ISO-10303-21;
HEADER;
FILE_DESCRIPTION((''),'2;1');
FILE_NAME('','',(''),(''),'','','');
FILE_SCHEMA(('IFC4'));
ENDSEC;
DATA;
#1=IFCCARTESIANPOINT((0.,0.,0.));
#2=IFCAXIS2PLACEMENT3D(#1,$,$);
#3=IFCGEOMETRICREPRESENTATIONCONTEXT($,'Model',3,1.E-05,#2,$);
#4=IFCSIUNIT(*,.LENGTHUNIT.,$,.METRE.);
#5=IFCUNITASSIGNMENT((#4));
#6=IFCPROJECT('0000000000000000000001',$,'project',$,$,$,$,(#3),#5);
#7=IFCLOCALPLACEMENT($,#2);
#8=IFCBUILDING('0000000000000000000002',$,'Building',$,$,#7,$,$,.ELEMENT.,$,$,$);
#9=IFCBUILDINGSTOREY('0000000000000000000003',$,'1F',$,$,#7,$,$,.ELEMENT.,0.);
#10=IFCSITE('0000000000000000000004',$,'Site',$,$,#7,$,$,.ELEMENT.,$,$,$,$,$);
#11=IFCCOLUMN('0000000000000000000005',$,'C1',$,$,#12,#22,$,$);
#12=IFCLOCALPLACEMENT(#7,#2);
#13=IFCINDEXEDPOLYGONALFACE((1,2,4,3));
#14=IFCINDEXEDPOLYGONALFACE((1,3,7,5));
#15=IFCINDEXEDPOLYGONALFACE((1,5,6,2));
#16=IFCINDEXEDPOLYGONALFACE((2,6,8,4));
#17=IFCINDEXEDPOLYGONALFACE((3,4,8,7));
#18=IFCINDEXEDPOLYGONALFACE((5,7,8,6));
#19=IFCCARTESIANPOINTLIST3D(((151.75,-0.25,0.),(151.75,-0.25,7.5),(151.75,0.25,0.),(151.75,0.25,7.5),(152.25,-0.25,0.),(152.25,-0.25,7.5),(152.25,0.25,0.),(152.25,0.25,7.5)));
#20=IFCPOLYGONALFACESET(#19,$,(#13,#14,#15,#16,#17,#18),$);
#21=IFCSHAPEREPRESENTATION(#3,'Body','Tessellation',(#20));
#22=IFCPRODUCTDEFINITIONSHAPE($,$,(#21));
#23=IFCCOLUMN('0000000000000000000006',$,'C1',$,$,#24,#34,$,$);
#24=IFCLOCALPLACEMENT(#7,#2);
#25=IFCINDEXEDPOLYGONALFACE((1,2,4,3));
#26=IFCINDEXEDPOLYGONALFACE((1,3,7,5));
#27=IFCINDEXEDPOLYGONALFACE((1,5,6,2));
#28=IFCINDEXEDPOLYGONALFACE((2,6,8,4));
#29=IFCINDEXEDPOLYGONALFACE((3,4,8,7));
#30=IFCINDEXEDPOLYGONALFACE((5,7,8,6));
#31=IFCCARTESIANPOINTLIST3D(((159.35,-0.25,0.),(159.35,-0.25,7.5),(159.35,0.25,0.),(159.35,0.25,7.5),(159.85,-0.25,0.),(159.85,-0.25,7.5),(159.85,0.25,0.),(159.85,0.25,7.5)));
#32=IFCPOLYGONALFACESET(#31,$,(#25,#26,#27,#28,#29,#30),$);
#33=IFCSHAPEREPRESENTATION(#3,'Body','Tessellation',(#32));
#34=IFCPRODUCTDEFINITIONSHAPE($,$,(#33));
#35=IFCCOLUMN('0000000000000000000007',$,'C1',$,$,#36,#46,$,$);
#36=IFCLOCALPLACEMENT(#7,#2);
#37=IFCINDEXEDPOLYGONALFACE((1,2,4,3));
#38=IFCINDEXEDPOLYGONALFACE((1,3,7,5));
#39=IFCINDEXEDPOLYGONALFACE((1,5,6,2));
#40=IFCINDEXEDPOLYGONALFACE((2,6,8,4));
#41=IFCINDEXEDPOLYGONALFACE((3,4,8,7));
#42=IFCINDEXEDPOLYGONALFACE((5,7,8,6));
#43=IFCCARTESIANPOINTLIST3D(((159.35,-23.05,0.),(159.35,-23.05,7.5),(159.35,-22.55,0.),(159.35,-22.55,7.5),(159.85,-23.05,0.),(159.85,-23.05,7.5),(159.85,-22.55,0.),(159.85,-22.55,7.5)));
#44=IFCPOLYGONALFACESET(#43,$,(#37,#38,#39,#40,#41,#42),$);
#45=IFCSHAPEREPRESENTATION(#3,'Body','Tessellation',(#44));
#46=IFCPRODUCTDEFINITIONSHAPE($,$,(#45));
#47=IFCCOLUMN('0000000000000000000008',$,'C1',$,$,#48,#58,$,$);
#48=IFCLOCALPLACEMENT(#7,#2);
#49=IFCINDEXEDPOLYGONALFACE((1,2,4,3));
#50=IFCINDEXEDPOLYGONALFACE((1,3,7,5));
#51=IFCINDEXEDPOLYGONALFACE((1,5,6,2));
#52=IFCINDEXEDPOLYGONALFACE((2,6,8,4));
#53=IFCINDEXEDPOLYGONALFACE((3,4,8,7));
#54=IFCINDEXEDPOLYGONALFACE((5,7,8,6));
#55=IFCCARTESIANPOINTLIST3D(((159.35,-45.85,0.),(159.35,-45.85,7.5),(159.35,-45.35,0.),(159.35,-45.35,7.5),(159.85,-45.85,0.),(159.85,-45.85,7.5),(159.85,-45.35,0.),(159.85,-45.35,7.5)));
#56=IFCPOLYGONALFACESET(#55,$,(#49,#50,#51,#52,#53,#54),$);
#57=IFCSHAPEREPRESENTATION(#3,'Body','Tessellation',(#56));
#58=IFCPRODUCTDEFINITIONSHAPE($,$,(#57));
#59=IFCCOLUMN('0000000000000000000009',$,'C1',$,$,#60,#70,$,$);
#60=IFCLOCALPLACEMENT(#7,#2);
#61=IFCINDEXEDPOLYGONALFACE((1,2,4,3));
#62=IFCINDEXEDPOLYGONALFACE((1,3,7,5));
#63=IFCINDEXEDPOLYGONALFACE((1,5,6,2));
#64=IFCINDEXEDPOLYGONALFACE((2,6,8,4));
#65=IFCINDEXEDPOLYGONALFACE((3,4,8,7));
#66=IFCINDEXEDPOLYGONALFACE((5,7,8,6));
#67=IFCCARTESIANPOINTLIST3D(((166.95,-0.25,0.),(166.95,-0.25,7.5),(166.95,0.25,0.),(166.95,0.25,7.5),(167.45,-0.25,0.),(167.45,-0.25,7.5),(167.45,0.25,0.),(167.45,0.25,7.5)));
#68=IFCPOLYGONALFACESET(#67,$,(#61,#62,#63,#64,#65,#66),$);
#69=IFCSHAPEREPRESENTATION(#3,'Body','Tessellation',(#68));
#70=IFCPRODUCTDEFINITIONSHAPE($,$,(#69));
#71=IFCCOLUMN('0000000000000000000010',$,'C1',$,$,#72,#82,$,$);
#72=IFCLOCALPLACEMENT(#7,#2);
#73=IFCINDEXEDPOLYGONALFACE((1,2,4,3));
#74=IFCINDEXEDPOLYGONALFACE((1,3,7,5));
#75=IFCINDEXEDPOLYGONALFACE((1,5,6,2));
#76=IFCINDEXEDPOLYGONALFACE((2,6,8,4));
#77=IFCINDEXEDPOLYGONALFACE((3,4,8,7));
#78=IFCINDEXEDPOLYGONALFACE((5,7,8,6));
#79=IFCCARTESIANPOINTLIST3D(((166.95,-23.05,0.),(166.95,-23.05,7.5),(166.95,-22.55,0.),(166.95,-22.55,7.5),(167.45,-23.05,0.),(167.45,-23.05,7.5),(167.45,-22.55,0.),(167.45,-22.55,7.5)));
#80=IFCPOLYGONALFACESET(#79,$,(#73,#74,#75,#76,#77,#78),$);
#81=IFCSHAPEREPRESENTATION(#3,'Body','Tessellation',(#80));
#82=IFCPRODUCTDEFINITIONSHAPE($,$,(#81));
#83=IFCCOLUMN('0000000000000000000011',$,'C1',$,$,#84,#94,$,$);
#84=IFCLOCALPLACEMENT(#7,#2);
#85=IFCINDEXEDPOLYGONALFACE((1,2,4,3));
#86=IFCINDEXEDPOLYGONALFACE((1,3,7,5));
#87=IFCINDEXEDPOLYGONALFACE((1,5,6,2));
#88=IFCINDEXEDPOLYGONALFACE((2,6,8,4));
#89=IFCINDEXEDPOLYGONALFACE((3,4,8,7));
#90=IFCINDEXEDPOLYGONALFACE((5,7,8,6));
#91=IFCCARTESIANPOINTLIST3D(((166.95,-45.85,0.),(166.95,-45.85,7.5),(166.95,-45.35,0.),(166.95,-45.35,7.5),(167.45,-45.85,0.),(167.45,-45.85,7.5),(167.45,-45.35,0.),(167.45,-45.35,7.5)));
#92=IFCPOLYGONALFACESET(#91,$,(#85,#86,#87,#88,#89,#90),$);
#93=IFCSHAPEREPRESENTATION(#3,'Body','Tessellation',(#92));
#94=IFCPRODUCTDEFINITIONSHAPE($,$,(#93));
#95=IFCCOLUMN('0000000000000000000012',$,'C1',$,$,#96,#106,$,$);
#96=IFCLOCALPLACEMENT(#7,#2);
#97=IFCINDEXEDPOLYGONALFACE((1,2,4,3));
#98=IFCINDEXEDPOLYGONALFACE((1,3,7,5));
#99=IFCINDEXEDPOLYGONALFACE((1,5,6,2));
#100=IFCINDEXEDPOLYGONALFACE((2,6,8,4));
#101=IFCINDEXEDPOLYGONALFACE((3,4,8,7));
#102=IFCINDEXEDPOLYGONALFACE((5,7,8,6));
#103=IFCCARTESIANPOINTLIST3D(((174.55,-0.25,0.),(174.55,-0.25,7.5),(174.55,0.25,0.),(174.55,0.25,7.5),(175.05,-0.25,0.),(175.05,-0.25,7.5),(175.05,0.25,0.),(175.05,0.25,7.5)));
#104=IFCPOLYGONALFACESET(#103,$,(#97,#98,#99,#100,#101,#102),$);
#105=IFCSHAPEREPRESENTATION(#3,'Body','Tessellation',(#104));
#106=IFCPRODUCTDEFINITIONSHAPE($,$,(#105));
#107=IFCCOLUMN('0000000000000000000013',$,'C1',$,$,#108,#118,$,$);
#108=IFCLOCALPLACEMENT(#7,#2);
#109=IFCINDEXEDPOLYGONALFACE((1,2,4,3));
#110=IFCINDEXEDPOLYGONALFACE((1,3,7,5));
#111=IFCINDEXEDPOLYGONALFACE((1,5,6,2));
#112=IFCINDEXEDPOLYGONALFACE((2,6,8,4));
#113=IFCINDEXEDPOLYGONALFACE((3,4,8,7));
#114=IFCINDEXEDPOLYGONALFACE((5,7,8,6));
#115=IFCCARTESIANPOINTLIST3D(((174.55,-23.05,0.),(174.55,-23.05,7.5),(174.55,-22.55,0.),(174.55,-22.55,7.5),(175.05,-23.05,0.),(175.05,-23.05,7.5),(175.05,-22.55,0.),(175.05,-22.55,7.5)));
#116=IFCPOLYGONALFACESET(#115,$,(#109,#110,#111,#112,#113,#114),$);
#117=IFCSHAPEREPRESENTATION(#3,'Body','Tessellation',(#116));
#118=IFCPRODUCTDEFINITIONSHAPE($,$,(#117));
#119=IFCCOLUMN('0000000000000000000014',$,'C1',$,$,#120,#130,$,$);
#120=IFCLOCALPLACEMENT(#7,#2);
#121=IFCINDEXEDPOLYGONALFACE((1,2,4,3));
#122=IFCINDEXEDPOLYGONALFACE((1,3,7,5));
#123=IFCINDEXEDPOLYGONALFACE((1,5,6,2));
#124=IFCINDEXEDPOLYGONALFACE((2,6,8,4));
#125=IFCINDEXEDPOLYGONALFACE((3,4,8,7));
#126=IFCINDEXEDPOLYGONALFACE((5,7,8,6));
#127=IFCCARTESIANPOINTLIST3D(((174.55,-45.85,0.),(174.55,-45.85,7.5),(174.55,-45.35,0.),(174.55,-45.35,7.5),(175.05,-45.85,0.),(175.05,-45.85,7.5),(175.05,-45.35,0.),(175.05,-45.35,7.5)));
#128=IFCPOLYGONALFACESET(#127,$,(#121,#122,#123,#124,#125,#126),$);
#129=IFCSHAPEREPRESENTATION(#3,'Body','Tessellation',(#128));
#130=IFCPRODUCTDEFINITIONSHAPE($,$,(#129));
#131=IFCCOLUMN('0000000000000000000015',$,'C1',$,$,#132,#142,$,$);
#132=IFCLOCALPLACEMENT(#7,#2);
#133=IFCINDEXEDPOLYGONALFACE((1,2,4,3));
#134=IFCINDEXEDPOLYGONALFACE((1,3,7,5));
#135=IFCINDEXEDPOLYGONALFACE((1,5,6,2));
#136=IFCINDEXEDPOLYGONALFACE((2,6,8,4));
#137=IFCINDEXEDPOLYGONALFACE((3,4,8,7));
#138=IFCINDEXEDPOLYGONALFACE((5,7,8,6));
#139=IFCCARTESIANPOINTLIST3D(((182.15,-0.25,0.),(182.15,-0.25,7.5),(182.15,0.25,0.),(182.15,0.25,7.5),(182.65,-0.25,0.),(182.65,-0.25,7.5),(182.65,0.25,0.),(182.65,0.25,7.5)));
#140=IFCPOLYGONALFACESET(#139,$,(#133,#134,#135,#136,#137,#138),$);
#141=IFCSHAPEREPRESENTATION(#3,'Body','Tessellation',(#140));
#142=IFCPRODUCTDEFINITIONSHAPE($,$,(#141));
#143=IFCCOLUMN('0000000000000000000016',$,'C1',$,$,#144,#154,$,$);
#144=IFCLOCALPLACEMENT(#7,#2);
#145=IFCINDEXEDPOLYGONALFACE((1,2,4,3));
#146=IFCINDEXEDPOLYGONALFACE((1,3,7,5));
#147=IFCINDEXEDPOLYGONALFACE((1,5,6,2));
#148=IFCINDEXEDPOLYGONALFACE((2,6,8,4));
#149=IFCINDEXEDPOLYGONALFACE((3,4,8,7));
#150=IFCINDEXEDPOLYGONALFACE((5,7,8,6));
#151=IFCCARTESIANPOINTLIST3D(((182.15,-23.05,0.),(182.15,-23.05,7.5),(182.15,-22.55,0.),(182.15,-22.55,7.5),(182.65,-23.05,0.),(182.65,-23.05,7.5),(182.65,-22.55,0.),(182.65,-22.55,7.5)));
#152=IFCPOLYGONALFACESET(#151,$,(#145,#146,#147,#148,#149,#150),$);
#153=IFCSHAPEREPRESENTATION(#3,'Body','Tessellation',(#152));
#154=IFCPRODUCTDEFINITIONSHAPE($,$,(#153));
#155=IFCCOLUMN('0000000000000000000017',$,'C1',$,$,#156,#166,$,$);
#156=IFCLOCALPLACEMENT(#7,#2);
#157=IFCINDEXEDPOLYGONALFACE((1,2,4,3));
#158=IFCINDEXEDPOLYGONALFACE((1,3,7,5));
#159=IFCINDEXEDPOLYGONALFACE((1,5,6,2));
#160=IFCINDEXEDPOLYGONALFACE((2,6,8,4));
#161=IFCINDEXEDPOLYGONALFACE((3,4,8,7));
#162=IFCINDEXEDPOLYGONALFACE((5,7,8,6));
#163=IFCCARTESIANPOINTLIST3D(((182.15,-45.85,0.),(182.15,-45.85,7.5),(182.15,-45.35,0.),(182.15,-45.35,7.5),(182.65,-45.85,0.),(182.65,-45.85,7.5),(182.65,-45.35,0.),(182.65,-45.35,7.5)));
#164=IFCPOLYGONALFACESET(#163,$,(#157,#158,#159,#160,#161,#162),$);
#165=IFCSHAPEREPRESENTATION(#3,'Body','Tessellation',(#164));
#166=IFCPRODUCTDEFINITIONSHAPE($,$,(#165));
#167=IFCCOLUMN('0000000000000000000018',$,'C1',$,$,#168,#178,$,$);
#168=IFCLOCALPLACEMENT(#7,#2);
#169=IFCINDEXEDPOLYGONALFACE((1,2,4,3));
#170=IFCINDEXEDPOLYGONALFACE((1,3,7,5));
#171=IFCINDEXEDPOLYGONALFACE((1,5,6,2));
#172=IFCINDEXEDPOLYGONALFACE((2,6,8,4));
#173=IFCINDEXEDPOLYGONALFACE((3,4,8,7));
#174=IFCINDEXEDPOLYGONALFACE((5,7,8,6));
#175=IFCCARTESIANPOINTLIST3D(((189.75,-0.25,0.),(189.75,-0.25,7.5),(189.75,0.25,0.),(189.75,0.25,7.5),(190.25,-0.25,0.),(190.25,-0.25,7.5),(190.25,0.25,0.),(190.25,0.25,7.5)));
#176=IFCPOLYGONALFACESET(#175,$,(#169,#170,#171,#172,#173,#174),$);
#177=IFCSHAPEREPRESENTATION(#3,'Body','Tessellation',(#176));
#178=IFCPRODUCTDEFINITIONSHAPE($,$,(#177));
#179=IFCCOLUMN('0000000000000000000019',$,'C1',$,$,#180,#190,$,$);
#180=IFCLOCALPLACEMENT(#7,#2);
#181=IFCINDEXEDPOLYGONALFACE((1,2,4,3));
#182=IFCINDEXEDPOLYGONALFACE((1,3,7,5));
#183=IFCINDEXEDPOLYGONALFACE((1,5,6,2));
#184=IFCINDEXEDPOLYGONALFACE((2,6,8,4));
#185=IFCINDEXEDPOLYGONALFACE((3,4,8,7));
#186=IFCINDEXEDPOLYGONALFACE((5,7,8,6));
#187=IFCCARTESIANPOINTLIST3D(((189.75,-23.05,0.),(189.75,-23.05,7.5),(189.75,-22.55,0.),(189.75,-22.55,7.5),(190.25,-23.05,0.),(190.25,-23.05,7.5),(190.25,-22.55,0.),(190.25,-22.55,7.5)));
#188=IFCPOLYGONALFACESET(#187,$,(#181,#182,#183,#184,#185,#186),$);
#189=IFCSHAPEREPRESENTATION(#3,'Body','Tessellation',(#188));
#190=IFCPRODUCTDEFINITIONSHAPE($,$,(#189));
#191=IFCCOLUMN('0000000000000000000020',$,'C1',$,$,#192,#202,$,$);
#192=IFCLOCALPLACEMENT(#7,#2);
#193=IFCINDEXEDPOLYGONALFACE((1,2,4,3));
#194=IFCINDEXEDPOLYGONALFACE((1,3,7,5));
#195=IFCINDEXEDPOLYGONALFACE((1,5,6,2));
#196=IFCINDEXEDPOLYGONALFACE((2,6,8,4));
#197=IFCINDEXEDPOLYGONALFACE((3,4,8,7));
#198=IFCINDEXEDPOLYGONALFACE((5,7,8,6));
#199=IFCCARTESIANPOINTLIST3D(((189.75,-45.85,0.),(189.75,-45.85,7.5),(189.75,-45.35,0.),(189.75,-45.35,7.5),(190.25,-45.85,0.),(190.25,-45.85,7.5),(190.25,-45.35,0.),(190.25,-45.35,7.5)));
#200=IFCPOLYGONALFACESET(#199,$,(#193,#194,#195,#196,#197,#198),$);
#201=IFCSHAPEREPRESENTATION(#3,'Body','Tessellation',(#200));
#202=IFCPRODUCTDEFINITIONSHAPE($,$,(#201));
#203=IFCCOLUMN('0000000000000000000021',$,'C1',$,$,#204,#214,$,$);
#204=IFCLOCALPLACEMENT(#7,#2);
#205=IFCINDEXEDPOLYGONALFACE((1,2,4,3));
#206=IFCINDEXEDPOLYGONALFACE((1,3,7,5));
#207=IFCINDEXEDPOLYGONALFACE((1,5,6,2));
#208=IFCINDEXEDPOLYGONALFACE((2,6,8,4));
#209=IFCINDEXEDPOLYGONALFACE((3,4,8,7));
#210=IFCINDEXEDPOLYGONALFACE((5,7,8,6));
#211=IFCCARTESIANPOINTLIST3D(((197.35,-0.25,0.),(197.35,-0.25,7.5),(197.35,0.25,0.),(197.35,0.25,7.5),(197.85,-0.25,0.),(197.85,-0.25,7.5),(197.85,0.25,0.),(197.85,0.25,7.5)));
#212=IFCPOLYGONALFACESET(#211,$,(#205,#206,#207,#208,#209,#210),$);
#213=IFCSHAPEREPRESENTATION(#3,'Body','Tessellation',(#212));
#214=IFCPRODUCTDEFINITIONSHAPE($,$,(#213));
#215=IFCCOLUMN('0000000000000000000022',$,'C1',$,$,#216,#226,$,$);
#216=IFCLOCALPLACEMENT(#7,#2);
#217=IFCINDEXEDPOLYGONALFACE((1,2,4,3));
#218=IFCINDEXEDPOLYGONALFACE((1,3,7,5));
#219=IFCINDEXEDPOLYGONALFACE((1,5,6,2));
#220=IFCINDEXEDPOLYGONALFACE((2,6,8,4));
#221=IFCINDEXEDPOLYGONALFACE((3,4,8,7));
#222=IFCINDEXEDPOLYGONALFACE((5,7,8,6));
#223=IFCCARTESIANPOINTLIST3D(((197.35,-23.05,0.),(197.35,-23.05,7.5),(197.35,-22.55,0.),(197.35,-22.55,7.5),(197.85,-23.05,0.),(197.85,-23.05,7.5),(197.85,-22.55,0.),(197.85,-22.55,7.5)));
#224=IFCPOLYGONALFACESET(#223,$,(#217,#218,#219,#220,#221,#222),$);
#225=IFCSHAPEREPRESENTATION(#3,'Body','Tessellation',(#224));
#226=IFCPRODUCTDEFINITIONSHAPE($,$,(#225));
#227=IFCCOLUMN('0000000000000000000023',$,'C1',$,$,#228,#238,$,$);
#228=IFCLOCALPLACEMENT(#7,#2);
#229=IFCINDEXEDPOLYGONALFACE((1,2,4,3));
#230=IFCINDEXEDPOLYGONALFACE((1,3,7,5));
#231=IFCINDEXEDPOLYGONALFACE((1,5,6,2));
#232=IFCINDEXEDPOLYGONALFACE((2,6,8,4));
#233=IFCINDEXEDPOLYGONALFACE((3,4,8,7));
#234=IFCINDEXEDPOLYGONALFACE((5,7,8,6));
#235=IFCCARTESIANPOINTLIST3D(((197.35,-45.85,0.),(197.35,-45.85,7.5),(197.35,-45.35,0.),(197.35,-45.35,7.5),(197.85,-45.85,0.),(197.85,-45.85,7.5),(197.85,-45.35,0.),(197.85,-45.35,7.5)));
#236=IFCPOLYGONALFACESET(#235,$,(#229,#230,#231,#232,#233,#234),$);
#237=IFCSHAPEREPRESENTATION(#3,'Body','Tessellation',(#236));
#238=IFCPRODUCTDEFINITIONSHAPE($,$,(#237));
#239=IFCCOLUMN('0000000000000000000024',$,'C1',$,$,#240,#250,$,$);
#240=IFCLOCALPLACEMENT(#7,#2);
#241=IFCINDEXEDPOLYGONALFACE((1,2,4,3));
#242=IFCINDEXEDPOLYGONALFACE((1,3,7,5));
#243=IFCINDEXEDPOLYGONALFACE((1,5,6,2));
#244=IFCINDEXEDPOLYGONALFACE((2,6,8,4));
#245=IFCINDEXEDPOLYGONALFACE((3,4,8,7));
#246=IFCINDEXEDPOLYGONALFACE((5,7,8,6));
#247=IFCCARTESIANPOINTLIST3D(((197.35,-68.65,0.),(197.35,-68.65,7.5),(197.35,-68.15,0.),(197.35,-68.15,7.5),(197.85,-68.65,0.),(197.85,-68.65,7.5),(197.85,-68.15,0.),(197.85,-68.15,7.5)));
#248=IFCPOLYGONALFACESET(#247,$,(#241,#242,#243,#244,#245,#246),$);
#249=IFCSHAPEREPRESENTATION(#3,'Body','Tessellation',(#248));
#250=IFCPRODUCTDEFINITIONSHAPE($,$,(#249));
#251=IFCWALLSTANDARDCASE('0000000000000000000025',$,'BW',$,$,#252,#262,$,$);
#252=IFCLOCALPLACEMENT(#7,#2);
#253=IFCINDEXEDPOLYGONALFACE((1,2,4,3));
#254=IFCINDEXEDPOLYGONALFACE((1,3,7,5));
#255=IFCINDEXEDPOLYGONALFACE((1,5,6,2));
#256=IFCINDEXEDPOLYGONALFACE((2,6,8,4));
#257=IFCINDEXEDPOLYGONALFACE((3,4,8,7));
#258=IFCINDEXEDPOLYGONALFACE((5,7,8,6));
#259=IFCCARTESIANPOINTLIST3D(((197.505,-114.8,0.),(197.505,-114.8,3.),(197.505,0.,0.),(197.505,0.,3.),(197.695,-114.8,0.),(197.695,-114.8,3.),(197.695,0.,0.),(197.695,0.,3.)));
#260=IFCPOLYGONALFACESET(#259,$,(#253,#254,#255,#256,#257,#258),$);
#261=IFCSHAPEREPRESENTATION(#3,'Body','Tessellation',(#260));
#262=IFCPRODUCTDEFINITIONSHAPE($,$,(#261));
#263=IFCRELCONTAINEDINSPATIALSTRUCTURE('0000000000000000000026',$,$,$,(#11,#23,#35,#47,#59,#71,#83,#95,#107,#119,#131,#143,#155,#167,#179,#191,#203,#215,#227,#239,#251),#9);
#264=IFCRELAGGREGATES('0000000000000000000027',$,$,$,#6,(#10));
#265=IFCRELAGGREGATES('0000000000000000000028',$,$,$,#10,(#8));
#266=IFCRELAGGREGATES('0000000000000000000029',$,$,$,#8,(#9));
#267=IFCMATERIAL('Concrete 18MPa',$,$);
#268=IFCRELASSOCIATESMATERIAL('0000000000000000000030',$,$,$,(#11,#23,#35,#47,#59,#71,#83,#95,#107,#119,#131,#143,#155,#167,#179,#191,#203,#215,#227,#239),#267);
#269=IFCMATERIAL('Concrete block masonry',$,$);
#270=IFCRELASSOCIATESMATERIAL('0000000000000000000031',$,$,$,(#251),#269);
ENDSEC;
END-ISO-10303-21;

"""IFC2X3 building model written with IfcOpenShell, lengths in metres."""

from ifc_helpers import new_model, si_unit, frame, origin, origin_2d, place, context, project, spatial, rectangle, extrude, material, element, save


model = new_model("IFC2X3")

# Units and contexts
model_context = context("Model", 3, precision=1e-05, world=origin())
ifc_project = project(units=[si_unit("LENGTHUNIT", "METRE")], contexts=[model_context])

# Site, building, storey
placement = place(None, origin())
site = spatial("IfcSite", under=ifc_project, at=placement, Name="Site", CompositionType="ELEMENT")
building = spatial("IfcBuilding", under=site, at=placement, Name="Building", CompositionType="ELEMENT")
storey = spatial("IfcBuildingStorey", under=building, at=placement, Name="1F", CompositionType="ELEMENT", Elevation=0.0)

# Columns
ifc_material_1 = material(Name="Concrete 18MPa")
for number, where, name in (
    (1, (152.0, 0.0, 0.0), "C1"),
    (2, (159.6, 0.0, 0.0), "C1"),
    (3, (159.6, -22.8, 0.0), "C1"),
    (4, (159.6, -45.6, 0.0), "C1"),
    (5, (167.2, 0.0, 0.0), "C1"),
    (6, (167.2, -22.8, 0.0), "C1"),
    (7, (167.2, -45.6, 0.0), "C1"),
    (8, (174.8, 0.0, 0.0), "C1"),
    (9, (174.8, -22.8, 0.0), "C1"),
    (10, (174.8, -45.6, 0.0), "C1"),
    (11, (182.4, 0.0, 0.0), "C1"),
    (12, (182.4, -22.8, 0.0), "C1"),
    (13, (182.4, -45.6, 0.0), "C1"),
    (14, (190.0, 0.0, 0.0), "C1"),
    (15, (190.0, -22.8, 0.0), "C1"),
    (16, (190.0, -45.6, 0.0), "C1"),
    (17, (197.6, 0.0, 0.0), "C1"),
    (18, (197.6, -22.8, 0.0), "C1"),
    (19, (197.6, -45.6, 0.0), "C1"),
    (20, (197.6, -68.4, 0.0), "C1"),
):
    element("IfcColumn", number, at=place(None, frame(where)), inside=storey, material=ifc_material_1, Name=name, context=model_context, shape_type="SweptSolid", body=[
        extrude(rectangle(XDim=0.5, YDim=0.5, at=origin_2d()), origin(), (0.0, 0.0, 1.0), 7.5),
    ])

# Wall
ifc_material_2 = material(Name="Concrete block masonry")
wall_placement = place(None, frame((197.6, -57.4, 0.0)))
element("IfcWallStandardCase", 21, at=wall_placement, inside=storey, material=ifc_material_2, Name="BW", context=model_context, shape_type="SweptSolid", body=[
    extrude(rectangle(XDim=0.19, YDim=114.8, at=origin_2d()), origin(), (0.0, 0.0, 1.0), 3.0),
])

save(model, "model.ifc")
